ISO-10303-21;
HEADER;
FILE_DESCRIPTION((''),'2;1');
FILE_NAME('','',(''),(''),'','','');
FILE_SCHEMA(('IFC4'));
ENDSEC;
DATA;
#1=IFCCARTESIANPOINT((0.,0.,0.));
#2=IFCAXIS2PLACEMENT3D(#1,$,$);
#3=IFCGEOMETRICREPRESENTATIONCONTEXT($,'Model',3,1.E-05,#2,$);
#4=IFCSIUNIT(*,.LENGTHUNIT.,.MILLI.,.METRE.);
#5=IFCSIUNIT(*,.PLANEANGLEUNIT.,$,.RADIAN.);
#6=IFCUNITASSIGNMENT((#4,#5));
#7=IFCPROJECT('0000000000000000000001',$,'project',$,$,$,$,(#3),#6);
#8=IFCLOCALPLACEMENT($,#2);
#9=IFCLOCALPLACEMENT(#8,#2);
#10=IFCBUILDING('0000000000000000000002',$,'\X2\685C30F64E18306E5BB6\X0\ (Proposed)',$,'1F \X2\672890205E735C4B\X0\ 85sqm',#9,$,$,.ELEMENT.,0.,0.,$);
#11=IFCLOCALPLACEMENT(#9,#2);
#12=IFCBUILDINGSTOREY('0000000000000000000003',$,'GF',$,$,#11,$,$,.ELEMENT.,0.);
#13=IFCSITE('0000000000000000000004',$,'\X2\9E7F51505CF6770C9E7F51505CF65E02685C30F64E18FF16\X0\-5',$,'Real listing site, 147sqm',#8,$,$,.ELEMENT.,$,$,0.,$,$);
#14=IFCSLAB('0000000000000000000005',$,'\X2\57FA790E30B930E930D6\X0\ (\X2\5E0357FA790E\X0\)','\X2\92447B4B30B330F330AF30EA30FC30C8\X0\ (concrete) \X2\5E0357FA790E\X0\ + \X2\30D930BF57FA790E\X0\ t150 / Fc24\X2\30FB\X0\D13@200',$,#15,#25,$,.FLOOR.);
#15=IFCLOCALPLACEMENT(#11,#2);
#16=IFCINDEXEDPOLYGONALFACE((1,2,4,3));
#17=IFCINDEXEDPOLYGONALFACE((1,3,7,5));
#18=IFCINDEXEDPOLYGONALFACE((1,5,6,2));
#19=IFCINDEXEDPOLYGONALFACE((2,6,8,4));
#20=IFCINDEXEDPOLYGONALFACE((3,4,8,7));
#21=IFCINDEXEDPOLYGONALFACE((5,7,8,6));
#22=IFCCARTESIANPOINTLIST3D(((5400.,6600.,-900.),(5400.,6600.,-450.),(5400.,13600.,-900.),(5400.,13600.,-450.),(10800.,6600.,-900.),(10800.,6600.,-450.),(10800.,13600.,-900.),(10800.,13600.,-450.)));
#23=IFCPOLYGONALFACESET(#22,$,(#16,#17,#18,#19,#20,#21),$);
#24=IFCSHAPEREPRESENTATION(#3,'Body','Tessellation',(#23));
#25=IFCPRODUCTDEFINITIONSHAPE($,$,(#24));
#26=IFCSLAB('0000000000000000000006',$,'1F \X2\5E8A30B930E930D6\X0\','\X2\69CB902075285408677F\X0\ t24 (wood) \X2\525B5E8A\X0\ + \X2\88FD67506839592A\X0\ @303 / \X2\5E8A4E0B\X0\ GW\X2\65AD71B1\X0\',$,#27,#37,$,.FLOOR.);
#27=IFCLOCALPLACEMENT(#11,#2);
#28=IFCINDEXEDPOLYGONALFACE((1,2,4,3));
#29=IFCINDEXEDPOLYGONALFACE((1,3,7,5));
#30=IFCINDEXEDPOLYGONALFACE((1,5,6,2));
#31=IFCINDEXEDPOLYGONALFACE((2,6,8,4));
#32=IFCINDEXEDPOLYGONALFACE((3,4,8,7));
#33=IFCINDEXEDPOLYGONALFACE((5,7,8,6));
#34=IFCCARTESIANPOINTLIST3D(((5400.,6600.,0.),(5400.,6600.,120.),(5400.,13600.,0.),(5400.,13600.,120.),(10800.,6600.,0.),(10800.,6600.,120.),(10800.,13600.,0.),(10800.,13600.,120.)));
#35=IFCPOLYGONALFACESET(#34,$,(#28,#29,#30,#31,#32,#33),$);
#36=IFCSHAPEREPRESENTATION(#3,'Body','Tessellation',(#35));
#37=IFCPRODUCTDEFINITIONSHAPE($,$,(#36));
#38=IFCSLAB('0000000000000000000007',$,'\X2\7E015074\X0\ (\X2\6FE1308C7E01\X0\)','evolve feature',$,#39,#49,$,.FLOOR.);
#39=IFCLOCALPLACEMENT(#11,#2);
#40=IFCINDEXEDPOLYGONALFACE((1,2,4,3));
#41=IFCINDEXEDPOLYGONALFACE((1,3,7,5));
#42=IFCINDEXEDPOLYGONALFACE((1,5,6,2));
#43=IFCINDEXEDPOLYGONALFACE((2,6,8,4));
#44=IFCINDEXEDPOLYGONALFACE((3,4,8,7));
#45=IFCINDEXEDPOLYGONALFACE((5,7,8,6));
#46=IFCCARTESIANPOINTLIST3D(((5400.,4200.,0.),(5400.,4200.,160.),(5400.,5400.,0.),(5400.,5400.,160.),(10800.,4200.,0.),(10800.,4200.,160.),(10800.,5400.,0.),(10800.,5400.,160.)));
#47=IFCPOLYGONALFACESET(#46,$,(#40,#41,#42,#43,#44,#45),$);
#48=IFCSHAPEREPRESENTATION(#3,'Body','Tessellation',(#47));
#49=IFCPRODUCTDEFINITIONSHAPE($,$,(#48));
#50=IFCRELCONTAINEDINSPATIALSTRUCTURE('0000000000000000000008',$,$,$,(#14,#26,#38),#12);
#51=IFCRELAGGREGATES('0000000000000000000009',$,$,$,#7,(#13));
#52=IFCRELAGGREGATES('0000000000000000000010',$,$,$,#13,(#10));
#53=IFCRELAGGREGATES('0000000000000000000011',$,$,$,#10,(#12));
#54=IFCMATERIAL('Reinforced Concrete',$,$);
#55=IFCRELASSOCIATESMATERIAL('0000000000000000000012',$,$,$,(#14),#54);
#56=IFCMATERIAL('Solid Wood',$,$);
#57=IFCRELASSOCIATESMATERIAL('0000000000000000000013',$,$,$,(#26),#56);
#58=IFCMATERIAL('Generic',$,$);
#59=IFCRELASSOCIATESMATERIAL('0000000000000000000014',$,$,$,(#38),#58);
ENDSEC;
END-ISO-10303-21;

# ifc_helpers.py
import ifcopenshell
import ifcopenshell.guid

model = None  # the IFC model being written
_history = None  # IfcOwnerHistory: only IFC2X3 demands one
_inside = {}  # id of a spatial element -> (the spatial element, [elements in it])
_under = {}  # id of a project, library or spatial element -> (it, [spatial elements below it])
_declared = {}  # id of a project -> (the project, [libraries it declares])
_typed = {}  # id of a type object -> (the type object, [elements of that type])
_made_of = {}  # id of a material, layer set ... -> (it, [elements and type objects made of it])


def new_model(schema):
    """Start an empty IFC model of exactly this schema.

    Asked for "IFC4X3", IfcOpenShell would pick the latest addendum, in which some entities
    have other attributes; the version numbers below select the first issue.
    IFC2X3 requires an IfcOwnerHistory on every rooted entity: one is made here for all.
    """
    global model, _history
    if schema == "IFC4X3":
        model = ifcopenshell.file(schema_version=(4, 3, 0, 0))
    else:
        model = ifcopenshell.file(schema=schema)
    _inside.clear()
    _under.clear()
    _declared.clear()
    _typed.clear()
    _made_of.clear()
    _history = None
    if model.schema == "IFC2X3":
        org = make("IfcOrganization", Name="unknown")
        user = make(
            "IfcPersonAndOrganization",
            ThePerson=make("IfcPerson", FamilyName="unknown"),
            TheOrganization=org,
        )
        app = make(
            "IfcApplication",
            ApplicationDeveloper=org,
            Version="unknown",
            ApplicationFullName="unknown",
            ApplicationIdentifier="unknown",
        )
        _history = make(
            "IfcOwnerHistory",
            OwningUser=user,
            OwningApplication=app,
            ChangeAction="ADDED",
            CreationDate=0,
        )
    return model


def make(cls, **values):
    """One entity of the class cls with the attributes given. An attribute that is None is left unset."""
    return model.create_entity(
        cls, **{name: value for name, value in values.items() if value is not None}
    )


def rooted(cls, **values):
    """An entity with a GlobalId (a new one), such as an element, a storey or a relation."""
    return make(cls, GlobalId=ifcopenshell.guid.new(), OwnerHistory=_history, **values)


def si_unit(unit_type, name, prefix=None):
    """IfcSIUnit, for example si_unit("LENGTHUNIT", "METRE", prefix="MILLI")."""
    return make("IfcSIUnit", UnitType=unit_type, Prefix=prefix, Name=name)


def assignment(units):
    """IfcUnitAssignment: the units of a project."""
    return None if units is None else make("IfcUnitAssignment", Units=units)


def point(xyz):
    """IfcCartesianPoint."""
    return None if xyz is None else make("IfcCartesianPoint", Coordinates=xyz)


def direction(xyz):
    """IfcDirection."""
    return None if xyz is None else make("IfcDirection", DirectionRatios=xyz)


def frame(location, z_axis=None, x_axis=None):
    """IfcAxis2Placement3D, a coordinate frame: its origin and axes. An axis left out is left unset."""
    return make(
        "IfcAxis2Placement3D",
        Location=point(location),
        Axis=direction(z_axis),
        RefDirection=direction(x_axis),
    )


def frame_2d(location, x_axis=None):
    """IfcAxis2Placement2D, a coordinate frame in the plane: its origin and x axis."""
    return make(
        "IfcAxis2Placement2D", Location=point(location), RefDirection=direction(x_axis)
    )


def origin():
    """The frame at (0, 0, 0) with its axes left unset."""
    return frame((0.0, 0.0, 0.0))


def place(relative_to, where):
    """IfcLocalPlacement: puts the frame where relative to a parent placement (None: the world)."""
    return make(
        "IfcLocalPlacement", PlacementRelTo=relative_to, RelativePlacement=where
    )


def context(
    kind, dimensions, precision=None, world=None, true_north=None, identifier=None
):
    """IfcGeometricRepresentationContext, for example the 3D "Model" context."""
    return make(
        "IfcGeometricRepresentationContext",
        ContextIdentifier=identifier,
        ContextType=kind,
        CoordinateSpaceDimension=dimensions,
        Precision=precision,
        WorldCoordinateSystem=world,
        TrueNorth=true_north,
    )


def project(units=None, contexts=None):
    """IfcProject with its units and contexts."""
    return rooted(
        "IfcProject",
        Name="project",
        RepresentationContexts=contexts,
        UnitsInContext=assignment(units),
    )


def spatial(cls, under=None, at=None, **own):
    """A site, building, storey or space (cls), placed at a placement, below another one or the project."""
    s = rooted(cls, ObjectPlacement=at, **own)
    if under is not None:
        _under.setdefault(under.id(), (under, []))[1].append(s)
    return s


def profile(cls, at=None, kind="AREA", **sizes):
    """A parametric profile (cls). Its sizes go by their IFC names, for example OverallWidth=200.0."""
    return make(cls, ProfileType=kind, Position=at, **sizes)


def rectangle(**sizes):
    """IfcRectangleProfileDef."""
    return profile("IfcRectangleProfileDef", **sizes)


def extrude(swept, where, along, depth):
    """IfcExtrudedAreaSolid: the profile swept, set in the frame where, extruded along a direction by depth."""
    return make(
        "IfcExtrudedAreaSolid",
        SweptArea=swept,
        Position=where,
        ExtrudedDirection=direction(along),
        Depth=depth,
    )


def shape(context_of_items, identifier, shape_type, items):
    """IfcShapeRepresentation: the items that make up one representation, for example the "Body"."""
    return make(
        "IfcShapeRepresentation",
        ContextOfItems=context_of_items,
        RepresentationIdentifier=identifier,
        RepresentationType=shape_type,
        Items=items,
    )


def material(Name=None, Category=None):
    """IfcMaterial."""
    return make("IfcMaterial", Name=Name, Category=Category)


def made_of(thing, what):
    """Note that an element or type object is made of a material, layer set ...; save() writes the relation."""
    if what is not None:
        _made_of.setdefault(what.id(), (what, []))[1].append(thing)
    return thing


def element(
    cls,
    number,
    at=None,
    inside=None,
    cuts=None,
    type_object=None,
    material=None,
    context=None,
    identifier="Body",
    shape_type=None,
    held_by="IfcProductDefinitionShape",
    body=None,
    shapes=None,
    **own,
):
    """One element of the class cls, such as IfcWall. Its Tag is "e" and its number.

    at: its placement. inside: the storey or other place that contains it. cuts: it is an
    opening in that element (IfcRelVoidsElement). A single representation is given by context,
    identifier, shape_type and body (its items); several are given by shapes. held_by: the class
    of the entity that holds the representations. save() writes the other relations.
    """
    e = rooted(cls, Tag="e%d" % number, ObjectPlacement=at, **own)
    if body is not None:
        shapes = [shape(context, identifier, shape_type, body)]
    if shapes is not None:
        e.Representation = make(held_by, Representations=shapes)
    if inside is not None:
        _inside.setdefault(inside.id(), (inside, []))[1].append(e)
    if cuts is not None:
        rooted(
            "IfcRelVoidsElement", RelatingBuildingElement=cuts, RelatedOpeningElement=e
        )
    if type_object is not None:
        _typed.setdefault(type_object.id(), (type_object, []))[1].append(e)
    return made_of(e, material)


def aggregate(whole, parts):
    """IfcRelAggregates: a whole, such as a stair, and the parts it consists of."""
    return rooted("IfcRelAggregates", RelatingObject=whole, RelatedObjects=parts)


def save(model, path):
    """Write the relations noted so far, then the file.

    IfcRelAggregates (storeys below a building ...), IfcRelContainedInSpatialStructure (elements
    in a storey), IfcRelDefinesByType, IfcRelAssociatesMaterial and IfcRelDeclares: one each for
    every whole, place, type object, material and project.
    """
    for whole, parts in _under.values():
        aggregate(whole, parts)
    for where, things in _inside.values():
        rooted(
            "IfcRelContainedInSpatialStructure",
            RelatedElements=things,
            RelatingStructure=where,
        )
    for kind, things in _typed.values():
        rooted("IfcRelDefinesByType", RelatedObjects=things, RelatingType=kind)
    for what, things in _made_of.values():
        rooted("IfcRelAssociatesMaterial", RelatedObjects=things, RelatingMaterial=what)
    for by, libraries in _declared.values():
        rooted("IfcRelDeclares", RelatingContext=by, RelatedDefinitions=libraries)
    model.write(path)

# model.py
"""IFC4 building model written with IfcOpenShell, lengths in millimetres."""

from ifc_helpers import new_model, si_unit, frame, frame_2d, origin, place, context, project, spatial, rectangle, extrude, material, element, save


model = new_model("IFC4")

# Units and contexts
model_context = context("Model", 3, precision=1e-05, world=origin())
ifc_project = project(units=[si_unit("LENGTHUNIT", "METRE", prefix="MILLI"), si_unit("PLANEANGLEUNIT", "RADIAN")], contexts=[model_context])

# Site, building, storey
site_placement = place(None, origin())
site = spatial("IfcSite", under=ifc_project, at=site_placement, Name="鹿児島県鹿児島市桜ヶ丘６-5", ObjectType="Real listing site, 147sqm", CompositionType="ELEMENT", RefElevation=0.0)
building_placement = place(site_placement, origin())
building = spatial("IfcBuilding", under=site, at=building_placement, Name="桜ヶ丘の家 (Proposed)", ObjectType="1F 木造平屋 85sqm", CompositionType="ELEMENT", ElevationOfRefHeight=0.0, ElevationOfTerrain=0.0)
storey_placement = place(building_placement, origin())
storey = spatial("IfcBuildingStorey", under=building, at=storey_placement, Name="GF", CompositionType="ELEMENT", Elevation=0.0)

# Slabs
ifc_material_1 = material(Name="Reinforced Concrete")
slab_1_placement = place(storey_placement, frame((2700.0, 3300.0, -450.0)))
element("IfcSlab", 1, at=slab_1_placement, inside=storey, material=ifc_material_1, Name="基礎スラブ (布基礎)", Description="鉄筋コンクリート (concrete) 布基礎 + ベタ基礎 t150 / Fc24・D13@200", PredefinedType="FLOOR", context=model_context, shape_type="SweptSolid", body=[
    extrude(rectangle(XDim=5400.0, YDim=7000.0, at=frame_2d((2700.0, 3500.0))), frame((2700.0, 3300.0, -450.0)), (0.0, 0.0, 1.0), 450.0),
])
ifc_material_2 = material(Name="Solid Wood")
slab_2_placement = place(storey_placement, frame((2700.0, 3300.0, 0.0)))
element("IfcSlab", 2, at=slab_2_placement, inside=storey, material=ifc_material_2, Name="1F 床スラブ", Description="構造用合板 t24 (wood) 剛床 + 製材根太 @303 / 床下 GW断熱", PredefinedType="FLOOR", context=model_context, shape_type="SweptSolid", body=[
    extrude(rectangle(XDim=5400.0, YDim=7000.0, at=frame_2d((2700.0, 3500.0))), frame((2700.0, 3300.0, 0.0)), (0.0, 0.0, 1.0), 120.0),
])
ifc_material_3 = material(Name="Generic")
slab_3_placement = place(storey_placement, frame((2700.0, 2100.0, 0.0)))
element("IfcSlab", 3, at=slab_3_placement, inside=storey, material=ifc_material_3, Name="縁側 (濡れ縁)", Description="evolve feature", PredefinedType="FLOOR", context=model_context, shape_type="SweptSolid", body=[
    extrude(rectangle(XDim=5400.0, YDim=1200.0, at=frame_2d((2700.0, 600.0))), frame((2700.0, 2100.0, 0.0)), (0.0, 0.0, 1.0), 160.0),
])

save(model, "model.ifc")
